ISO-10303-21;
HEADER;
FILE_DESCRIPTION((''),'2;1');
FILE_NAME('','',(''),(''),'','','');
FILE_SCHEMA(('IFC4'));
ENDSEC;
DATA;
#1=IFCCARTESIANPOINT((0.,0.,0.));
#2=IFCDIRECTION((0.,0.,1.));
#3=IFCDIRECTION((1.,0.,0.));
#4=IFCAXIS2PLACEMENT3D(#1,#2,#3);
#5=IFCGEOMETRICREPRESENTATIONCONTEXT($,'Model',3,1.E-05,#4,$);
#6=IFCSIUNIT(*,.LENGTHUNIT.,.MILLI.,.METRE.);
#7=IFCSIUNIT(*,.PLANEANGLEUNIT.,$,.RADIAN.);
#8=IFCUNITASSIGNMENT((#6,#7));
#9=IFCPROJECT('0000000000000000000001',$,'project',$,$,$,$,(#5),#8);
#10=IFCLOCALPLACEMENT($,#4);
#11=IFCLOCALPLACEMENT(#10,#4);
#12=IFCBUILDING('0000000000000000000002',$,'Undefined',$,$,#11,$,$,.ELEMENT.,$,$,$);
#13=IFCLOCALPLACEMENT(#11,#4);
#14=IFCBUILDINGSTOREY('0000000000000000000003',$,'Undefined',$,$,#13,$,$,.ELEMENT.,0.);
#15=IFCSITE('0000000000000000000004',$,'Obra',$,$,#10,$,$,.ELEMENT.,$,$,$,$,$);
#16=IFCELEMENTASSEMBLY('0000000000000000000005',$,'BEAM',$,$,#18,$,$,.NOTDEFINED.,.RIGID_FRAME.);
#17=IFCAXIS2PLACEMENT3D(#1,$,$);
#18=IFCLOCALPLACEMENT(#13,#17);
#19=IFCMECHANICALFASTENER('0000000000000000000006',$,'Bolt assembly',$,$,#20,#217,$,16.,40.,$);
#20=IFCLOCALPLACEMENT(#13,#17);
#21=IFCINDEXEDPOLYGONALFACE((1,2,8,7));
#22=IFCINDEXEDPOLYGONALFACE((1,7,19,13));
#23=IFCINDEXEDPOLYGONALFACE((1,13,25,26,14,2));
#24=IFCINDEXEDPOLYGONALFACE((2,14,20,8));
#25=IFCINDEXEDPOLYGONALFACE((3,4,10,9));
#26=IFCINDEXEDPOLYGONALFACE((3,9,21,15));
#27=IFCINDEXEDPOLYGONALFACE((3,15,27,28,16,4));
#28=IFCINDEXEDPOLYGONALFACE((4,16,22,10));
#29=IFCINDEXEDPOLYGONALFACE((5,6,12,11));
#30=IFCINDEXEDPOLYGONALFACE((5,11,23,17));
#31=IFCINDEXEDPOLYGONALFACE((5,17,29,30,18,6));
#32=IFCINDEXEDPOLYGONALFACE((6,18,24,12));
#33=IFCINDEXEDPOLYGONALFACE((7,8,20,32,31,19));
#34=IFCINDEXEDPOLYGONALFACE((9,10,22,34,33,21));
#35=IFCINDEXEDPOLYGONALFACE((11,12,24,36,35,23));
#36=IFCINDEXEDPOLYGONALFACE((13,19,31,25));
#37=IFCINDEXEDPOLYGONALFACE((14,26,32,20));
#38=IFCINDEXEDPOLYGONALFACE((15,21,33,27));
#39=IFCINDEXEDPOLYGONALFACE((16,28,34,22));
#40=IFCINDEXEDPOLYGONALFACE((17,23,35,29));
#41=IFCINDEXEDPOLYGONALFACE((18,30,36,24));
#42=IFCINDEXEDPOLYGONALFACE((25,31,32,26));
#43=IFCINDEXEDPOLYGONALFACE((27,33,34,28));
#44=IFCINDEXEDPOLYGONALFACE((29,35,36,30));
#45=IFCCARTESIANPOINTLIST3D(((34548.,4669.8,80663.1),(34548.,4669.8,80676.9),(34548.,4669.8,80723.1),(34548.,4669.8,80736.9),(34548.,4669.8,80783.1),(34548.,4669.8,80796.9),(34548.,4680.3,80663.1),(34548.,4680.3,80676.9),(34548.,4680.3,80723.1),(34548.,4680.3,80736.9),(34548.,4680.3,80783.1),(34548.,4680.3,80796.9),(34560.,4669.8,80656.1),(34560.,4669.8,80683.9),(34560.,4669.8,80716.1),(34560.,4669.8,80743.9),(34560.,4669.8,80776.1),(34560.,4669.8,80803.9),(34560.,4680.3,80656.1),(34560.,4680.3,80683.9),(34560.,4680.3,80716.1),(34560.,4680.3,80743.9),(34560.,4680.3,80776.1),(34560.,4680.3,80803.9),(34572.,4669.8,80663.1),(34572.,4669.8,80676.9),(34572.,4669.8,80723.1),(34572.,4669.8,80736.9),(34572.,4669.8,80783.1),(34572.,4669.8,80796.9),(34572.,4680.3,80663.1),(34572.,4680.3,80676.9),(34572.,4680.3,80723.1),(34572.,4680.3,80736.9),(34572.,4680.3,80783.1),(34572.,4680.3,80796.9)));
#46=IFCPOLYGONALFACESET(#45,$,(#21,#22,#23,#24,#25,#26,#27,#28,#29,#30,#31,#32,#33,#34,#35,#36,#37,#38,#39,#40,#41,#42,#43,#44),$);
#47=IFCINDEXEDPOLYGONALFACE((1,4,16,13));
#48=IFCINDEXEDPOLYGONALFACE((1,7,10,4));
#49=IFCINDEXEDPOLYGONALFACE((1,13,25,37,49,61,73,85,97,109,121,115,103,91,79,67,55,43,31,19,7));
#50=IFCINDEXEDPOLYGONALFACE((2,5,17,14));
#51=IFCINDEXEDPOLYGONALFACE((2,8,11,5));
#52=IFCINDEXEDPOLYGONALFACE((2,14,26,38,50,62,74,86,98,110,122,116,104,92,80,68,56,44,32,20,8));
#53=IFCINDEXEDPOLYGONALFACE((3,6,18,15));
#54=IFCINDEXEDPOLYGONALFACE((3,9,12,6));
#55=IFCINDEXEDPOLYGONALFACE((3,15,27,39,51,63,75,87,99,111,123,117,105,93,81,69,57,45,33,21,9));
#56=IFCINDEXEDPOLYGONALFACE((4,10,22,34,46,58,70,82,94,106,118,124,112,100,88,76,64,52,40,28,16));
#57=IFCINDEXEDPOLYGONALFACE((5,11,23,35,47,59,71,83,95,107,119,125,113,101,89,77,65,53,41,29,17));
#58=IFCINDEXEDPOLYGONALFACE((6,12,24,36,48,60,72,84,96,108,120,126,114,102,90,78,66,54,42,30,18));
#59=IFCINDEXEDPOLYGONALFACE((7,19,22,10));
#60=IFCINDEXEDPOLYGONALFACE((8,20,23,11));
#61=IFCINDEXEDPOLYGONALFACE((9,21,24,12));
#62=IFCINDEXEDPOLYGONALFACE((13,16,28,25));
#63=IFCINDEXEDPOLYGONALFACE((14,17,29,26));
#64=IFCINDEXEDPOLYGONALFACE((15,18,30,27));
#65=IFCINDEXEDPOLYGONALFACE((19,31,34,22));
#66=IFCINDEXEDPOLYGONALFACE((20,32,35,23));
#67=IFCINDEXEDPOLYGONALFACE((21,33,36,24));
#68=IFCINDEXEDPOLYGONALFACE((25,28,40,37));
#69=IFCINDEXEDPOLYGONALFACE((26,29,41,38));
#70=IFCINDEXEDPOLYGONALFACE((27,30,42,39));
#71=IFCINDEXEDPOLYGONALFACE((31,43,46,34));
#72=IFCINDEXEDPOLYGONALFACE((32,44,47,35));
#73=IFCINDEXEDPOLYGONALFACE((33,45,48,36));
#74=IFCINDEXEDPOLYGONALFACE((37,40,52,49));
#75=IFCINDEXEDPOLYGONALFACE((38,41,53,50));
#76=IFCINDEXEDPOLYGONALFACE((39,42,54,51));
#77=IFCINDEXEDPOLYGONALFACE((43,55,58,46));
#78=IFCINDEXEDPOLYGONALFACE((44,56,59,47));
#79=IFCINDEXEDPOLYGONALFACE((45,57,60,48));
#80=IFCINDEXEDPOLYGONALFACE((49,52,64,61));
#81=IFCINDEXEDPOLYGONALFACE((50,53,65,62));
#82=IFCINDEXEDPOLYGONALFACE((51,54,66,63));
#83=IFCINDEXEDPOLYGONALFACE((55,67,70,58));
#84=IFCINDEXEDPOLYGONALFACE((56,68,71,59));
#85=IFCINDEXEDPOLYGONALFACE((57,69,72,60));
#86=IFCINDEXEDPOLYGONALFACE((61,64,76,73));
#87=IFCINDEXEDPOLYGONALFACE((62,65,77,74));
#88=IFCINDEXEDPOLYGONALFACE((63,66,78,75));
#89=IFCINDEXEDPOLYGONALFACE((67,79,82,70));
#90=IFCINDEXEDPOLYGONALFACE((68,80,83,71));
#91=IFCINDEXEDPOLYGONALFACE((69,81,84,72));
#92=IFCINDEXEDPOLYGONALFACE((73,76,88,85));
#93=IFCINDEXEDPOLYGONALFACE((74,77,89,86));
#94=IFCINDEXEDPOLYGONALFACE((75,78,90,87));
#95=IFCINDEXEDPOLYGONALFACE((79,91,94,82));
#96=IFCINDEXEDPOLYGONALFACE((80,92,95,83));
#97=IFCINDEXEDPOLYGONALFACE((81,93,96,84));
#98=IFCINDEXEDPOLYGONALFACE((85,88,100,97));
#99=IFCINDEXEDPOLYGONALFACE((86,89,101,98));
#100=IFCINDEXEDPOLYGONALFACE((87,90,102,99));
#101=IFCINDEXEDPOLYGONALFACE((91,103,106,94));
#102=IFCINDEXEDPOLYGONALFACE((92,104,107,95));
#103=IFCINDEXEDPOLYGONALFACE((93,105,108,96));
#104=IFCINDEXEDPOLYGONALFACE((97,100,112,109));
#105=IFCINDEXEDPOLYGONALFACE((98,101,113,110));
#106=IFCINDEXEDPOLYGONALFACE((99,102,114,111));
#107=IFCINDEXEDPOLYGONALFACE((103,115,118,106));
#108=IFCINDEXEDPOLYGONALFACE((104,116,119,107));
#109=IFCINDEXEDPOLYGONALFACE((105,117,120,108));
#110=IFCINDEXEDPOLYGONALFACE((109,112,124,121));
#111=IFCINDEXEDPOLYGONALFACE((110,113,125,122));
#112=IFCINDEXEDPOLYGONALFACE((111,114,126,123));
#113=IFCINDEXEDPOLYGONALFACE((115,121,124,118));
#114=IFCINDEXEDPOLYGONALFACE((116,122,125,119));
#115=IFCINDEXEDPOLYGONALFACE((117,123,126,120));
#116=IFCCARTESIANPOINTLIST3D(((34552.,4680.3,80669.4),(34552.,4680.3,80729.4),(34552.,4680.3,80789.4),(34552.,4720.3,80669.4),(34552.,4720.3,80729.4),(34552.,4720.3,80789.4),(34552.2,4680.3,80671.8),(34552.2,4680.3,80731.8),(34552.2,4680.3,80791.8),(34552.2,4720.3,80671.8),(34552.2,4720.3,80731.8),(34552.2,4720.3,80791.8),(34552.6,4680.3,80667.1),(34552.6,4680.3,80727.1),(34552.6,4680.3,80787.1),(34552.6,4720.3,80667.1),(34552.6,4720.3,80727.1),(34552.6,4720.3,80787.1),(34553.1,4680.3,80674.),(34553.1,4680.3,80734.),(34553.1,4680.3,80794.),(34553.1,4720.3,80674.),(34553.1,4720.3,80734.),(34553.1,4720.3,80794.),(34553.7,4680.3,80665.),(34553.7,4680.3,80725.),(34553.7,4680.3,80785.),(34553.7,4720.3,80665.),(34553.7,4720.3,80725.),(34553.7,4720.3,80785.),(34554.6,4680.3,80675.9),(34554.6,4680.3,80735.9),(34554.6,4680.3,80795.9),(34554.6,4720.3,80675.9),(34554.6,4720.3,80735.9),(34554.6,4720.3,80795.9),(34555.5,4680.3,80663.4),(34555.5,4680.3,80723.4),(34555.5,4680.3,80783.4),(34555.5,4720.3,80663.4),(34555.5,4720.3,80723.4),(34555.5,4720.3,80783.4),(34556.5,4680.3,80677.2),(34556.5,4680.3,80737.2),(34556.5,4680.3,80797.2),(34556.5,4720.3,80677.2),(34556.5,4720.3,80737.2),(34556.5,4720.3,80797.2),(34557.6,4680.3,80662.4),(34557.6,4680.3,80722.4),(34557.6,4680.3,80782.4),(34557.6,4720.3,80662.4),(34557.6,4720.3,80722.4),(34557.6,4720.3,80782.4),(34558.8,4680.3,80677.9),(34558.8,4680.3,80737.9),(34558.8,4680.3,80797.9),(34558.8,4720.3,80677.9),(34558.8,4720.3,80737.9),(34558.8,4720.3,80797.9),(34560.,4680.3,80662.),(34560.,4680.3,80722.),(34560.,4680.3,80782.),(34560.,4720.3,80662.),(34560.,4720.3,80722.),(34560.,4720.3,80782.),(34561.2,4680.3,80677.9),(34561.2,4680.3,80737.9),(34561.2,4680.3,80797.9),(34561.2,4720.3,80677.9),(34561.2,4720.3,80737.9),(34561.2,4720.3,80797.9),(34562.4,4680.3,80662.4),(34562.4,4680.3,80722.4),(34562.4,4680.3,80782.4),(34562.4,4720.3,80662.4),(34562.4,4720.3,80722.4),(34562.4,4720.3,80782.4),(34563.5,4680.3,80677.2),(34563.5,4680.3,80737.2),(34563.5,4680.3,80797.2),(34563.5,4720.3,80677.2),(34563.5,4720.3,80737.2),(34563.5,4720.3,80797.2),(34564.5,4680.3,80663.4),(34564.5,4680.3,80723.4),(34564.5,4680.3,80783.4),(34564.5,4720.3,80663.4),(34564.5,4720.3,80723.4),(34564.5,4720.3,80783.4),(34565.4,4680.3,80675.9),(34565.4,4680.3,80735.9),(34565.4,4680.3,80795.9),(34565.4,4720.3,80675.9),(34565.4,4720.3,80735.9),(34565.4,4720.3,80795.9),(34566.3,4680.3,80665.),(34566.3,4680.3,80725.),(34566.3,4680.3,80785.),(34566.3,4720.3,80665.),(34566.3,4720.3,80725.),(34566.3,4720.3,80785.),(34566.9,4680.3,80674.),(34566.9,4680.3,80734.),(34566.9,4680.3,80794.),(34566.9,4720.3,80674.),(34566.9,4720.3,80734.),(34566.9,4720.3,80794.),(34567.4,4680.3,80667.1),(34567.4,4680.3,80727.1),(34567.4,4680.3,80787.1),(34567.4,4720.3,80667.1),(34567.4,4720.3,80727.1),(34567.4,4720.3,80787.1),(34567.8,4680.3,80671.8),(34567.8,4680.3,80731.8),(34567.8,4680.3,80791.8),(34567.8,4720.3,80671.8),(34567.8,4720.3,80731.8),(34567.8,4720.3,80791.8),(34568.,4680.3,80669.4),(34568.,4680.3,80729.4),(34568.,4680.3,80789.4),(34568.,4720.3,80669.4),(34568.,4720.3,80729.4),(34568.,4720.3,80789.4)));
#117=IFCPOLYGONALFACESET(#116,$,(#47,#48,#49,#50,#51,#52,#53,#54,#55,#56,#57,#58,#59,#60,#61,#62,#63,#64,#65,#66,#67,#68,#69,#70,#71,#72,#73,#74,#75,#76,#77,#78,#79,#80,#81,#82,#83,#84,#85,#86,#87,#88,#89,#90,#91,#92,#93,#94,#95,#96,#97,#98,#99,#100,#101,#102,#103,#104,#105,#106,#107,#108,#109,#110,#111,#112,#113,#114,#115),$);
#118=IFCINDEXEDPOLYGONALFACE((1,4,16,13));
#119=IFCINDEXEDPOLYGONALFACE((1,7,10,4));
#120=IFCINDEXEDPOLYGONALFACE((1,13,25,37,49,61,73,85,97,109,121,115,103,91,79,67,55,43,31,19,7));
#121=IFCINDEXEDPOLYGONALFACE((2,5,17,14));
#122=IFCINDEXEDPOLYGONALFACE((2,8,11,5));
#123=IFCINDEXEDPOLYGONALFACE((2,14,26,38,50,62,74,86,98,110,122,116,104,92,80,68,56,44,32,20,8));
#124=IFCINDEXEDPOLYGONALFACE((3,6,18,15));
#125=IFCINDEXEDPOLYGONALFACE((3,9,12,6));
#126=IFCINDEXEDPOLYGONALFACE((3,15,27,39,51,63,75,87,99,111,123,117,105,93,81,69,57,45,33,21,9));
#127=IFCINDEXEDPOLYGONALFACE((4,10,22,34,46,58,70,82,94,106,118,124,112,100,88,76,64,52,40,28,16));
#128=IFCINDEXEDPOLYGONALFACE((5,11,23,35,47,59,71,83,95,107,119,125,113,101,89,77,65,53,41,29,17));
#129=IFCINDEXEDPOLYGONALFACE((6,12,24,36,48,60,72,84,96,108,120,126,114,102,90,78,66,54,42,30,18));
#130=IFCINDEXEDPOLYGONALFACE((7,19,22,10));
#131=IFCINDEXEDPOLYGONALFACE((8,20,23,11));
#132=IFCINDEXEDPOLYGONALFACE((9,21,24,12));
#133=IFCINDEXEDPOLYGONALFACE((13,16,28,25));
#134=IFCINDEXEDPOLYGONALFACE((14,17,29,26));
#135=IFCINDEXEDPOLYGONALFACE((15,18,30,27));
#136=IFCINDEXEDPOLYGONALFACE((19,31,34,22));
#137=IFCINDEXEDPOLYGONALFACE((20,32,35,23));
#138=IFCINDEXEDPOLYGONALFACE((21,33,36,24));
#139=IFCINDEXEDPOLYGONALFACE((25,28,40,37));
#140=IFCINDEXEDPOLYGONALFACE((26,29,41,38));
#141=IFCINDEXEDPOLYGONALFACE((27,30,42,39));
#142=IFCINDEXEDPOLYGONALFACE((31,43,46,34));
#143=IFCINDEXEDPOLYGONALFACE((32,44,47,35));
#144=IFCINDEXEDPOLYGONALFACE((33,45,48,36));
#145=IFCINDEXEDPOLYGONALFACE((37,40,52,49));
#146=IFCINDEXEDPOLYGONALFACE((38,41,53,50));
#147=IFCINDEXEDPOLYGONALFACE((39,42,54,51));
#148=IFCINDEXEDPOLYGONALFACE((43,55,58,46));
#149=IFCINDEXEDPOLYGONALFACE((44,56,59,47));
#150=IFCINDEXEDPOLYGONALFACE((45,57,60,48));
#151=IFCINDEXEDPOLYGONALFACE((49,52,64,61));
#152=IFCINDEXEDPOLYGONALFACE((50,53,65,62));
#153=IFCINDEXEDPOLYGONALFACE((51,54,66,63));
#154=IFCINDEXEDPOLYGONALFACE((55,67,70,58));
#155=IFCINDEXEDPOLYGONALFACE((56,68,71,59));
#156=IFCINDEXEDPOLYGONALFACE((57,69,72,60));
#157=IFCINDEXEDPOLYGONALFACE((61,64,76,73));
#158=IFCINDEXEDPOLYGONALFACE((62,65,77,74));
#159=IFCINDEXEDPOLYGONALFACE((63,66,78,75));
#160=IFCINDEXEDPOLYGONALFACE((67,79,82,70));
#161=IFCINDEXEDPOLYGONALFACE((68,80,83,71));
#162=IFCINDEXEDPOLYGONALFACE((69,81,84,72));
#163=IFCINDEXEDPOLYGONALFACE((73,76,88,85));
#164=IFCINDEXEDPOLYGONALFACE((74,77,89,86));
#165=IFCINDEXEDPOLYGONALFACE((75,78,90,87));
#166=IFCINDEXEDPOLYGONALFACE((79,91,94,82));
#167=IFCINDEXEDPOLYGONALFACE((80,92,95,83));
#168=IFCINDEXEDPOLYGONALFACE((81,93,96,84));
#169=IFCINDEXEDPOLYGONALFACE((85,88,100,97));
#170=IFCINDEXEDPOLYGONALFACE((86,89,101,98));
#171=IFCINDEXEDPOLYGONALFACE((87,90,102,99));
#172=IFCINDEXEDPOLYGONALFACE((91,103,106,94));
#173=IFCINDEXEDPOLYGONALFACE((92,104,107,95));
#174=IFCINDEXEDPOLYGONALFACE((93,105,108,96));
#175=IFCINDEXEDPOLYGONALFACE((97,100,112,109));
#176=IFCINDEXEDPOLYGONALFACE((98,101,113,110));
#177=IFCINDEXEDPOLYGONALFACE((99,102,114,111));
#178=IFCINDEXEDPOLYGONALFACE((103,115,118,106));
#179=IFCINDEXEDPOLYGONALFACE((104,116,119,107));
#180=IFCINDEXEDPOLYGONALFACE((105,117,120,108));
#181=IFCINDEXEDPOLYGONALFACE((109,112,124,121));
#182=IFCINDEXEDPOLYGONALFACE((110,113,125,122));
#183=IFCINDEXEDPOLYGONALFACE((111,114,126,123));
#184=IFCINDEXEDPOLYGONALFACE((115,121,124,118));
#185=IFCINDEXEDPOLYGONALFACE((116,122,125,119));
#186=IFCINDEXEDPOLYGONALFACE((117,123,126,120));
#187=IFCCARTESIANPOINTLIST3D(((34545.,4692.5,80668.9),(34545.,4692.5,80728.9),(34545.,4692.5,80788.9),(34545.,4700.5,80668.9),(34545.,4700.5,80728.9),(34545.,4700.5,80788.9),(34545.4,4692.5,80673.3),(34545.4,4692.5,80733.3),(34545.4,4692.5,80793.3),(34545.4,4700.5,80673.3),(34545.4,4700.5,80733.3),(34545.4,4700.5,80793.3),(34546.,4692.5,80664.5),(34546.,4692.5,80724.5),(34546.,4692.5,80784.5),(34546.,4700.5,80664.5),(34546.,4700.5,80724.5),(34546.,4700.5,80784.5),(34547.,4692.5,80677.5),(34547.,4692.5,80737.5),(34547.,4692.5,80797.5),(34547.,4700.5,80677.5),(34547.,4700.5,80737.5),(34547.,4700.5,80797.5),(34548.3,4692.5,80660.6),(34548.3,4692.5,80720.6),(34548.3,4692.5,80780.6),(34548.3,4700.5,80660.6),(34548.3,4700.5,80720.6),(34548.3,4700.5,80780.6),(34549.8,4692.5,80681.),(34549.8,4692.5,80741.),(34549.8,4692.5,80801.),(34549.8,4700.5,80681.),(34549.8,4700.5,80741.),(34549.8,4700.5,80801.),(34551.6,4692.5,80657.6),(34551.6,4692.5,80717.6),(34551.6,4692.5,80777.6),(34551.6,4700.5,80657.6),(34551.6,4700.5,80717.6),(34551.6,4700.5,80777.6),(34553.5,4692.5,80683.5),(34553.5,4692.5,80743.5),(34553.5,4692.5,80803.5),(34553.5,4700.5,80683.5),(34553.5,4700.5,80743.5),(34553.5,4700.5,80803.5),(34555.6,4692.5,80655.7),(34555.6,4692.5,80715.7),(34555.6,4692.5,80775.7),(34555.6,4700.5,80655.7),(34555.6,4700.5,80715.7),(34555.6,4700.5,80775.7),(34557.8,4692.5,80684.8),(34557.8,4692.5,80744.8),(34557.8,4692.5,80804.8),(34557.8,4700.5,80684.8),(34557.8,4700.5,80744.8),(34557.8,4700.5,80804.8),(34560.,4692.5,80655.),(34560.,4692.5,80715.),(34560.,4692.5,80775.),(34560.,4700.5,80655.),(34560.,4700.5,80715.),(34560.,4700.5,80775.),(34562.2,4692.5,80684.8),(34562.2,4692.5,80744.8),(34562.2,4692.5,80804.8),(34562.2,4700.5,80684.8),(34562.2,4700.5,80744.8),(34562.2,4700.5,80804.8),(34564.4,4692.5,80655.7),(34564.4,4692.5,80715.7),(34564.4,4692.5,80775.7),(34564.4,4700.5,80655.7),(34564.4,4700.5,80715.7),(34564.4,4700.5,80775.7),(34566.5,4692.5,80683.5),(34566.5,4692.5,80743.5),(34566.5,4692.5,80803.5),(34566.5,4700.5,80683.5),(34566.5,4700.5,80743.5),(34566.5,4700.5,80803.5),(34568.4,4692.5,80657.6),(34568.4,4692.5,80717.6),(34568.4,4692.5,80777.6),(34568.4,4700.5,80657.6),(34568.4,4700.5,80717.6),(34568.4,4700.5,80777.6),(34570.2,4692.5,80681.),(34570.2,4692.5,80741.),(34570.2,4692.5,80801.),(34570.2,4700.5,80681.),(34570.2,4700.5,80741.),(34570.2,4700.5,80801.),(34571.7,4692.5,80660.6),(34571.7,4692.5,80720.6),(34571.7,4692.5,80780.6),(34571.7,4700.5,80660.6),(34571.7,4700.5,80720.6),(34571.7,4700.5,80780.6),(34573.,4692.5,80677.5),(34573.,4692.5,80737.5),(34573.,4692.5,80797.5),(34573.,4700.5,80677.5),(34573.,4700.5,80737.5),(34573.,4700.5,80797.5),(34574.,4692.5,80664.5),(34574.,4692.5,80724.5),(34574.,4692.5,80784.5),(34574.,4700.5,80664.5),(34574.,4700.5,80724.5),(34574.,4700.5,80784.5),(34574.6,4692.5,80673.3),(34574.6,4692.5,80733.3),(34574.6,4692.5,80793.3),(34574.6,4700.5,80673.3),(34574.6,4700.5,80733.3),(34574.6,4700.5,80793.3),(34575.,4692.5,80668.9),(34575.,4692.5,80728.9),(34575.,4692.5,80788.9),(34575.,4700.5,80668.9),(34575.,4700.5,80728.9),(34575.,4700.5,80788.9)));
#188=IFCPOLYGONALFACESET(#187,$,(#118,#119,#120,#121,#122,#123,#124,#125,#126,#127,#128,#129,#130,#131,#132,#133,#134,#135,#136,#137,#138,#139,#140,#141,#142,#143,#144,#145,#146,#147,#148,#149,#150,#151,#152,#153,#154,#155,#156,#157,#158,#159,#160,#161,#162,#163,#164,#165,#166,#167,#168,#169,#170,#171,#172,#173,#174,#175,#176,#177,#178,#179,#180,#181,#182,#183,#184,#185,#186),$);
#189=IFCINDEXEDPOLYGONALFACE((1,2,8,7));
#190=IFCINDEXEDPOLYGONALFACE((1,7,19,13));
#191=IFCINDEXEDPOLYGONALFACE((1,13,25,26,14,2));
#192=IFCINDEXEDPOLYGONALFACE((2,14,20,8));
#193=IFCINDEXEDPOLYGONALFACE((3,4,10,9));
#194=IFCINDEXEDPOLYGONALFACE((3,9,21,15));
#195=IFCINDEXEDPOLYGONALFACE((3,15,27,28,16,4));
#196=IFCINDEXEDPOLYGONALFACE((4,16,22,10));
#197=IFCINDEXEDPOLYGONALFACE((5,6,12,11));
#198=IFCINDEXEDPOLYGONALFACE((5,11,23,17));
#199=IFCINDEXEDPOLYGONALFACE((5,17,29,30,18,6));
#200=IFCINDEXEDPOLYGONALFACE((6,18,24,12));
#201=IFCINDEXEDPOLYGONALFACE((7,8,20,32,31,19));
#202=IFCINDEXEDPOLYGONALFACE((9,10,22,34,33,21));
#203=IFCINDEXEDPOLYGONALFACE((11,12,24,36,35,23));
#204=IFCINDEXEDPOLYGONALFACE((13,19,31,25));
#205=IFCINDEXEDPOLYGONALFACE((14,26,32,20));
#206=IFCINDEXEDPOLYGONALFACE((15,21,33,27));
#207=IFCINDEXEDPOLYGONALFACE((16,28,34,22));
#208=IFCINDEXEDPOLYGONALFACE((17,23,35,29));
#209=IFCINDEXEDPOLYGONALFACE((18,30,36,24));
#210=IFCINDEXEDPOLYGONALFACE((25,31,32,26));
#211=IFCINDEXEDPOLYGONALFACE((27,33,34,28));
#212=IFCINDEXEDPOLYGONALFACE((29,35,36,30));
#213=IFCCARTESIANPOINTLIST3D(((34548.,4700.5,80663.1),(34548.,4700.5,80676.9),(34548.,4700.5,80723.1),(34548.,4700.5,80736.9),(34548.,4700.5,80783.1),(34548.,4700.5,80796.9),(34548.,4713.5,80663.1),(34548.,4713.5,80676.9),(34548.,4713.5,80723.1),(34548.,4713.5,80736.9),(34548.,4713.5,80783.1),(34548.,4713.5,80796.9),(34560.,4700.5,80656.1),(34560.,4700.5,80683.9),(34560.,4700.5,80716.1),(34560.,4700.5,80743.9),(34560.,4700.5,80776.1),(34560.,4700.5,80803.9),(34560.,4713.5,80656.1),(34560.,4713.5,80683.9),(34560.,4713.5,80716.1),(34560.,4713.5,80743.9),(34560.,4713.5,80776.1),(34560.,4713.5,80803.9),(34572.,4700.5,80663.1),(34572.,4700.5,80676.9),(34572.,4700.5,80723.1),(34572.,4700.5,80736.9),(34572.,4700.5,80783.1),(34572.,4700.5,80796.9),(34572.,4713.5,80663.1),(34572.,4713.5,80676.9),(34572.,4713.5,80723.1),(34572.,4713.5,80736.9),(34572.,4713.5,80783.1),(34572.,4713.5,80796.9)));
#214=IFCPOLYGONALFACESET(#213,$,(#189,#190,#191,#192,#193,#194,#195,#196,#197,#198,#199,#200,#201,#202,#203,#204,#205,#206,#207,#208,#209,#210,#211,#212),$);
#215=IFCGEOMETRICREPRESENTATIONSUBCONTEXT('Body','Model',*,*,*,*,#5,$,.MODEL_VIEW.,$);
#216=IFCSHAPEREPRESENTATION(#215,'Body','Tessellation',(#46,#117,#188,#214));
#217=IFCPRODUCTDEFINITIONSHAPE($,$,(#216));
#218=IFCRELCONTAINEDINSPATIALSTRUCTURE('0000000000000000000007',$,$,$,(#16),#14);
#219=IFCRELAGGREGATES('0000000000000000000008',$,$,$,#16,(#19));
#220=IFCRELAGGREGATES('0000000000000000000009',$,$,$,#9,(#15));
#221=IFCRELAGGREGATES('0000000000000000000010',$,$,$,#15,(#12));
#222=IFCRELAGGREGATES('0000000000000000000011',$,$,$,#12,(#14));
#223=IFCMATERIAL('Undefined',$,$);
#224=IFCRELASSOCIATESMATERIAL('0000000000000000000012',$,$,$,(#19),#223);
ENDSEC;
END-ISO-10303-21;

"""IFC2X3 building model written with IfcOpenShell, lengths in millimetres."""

from ifc_helpers import new_model, si_unit, frame, origin_with_axes, origin_2d_with_axis, place, context, subcontext, project, spatial, polyline, circle, outline, extrude, source, transform, mapped, material, element, aggregate, save


model = new_model("IFC2X3")

# Units and contexts
model_context = context("Model", 3, precision=1e-05, world=origin_with_axes())
body_context = subcontext(model_context, "Body", "Model", "MODEL_VIEW")
ifc_project = project(units=[si_unit("LENGTHUNIT", "METRE", prefix="MILLI"), si_unit("PLANEANGLEUNIT", "RADIAN")], contexts=[model_context])

# Site, building, storey
site_placement = place(None, origin_with_axes())
site = spatial("IfcSite", under=ifc_project, at=site_placement, Name="Obra", CompositionType="ELEMENT")
building_placement = place(site_placement, origin_with_axes())
building = spatial("IfcBuilding", under=site, at=building_placement, Name="Undefined", CompositionType="ELEMENT")
storey_placement = place(building_placement, origin_with_axes())
storey = spatial("IfcBuildingStorey", under=building, at=storey_placement, Name="Undefined", CompositionType="ELEMENT", Elevation=0.0)

# Shared definitions
ifc_material_1 = material(Name="Undefined")

# Element assembly, mechanical fastener
assembly_1_placement = place(storey_placement, origin_with_axes())
assembly_1 = element("IfcElementAssembly", 1, at=assembly_1_placement, inside=storey, Name="BEAM", AssemblyPlace="NOTDEFINED", PredefinedType="RIGID_FRAME")
shared_shape_1 = source(origin_with_axes(), body_context, "Body", "SweptSolid", [
    extrude(outline(polyline([(13.9, 0.0), (6.9, 12.0), (-6.9, 12.0), (-13.9, 0.0), (-6.9, -12.0), (6.9, -12.0), (13.9, 0.0)])), frame((0.0, -19.7, 0.0), z_axis=(0.0, 1.0, 0.0), x_axis=(1.0, 0.0, 0.0)), (0.0, 0.0, 1.0), 10.6),
    extrude(circle(Radius=8.0, at=origin_2d_with_axis()), frame((0.0, -9.1, 0.0), z_axis=(0.0, 1.0, 0.0), x_axis=(1.0, 0.0, 0.0)), (0.0, 0.0, 1.0), 40.0),
    extrude(circle(Radius=15.0, at=origin_2d_with_axis()), frame((0.0, 3.1, 0.0), z_axis=(0.0, 1.0, 0.0), x_axis=(1.0, 0.0, 0.0)), (0.0, 0.0, 1.0), 8.0),
    extrude(outline(polyline([(13.9, 0.0), (6.9, 12.0), (-6.9, 12.0), (-13.9, 0.0), (-6.9, -12.0), (6.9, -12.0), (13.9, 0.0)])), frame((0.0, 11.1, 0.0), z_axis=(0.0, 1.0, 0.0), x_axis=(1.0, 0.0, 0.0)), (0.0, 0.0, 1.0), 13.0),
])
mechanical_fastener_1_placement = place(assembly_1_placement, frame((34510.0, 4689.4, 80850.0), z_axis=(1.0, 0.0, 0.0), x_axis=(0.0, 0.0, -1.0)))
mechanical_fastener_1 = element("IfcMechanicalFastener", 2, at=mechanical_fastener_1_placement, material=ifc_material_1, Name="Bolt assembly", NominalDiameter=16.0, NominalLength=40.0, context=body_context, shape_type="MappedRepresentation", body=[
    mapped(shared_shape_1, transform((60.0, 0.0, 50.0))),
    mapped(shared_shape_1, transform((120.0, 0.0, 50.0))),
    mapped(shared_shape_1, transform((180.0, 0.0, 50.0))),
])
aggregate(assembly_1, [mechanical_fastener_1])

save(model, "model.ifc")
